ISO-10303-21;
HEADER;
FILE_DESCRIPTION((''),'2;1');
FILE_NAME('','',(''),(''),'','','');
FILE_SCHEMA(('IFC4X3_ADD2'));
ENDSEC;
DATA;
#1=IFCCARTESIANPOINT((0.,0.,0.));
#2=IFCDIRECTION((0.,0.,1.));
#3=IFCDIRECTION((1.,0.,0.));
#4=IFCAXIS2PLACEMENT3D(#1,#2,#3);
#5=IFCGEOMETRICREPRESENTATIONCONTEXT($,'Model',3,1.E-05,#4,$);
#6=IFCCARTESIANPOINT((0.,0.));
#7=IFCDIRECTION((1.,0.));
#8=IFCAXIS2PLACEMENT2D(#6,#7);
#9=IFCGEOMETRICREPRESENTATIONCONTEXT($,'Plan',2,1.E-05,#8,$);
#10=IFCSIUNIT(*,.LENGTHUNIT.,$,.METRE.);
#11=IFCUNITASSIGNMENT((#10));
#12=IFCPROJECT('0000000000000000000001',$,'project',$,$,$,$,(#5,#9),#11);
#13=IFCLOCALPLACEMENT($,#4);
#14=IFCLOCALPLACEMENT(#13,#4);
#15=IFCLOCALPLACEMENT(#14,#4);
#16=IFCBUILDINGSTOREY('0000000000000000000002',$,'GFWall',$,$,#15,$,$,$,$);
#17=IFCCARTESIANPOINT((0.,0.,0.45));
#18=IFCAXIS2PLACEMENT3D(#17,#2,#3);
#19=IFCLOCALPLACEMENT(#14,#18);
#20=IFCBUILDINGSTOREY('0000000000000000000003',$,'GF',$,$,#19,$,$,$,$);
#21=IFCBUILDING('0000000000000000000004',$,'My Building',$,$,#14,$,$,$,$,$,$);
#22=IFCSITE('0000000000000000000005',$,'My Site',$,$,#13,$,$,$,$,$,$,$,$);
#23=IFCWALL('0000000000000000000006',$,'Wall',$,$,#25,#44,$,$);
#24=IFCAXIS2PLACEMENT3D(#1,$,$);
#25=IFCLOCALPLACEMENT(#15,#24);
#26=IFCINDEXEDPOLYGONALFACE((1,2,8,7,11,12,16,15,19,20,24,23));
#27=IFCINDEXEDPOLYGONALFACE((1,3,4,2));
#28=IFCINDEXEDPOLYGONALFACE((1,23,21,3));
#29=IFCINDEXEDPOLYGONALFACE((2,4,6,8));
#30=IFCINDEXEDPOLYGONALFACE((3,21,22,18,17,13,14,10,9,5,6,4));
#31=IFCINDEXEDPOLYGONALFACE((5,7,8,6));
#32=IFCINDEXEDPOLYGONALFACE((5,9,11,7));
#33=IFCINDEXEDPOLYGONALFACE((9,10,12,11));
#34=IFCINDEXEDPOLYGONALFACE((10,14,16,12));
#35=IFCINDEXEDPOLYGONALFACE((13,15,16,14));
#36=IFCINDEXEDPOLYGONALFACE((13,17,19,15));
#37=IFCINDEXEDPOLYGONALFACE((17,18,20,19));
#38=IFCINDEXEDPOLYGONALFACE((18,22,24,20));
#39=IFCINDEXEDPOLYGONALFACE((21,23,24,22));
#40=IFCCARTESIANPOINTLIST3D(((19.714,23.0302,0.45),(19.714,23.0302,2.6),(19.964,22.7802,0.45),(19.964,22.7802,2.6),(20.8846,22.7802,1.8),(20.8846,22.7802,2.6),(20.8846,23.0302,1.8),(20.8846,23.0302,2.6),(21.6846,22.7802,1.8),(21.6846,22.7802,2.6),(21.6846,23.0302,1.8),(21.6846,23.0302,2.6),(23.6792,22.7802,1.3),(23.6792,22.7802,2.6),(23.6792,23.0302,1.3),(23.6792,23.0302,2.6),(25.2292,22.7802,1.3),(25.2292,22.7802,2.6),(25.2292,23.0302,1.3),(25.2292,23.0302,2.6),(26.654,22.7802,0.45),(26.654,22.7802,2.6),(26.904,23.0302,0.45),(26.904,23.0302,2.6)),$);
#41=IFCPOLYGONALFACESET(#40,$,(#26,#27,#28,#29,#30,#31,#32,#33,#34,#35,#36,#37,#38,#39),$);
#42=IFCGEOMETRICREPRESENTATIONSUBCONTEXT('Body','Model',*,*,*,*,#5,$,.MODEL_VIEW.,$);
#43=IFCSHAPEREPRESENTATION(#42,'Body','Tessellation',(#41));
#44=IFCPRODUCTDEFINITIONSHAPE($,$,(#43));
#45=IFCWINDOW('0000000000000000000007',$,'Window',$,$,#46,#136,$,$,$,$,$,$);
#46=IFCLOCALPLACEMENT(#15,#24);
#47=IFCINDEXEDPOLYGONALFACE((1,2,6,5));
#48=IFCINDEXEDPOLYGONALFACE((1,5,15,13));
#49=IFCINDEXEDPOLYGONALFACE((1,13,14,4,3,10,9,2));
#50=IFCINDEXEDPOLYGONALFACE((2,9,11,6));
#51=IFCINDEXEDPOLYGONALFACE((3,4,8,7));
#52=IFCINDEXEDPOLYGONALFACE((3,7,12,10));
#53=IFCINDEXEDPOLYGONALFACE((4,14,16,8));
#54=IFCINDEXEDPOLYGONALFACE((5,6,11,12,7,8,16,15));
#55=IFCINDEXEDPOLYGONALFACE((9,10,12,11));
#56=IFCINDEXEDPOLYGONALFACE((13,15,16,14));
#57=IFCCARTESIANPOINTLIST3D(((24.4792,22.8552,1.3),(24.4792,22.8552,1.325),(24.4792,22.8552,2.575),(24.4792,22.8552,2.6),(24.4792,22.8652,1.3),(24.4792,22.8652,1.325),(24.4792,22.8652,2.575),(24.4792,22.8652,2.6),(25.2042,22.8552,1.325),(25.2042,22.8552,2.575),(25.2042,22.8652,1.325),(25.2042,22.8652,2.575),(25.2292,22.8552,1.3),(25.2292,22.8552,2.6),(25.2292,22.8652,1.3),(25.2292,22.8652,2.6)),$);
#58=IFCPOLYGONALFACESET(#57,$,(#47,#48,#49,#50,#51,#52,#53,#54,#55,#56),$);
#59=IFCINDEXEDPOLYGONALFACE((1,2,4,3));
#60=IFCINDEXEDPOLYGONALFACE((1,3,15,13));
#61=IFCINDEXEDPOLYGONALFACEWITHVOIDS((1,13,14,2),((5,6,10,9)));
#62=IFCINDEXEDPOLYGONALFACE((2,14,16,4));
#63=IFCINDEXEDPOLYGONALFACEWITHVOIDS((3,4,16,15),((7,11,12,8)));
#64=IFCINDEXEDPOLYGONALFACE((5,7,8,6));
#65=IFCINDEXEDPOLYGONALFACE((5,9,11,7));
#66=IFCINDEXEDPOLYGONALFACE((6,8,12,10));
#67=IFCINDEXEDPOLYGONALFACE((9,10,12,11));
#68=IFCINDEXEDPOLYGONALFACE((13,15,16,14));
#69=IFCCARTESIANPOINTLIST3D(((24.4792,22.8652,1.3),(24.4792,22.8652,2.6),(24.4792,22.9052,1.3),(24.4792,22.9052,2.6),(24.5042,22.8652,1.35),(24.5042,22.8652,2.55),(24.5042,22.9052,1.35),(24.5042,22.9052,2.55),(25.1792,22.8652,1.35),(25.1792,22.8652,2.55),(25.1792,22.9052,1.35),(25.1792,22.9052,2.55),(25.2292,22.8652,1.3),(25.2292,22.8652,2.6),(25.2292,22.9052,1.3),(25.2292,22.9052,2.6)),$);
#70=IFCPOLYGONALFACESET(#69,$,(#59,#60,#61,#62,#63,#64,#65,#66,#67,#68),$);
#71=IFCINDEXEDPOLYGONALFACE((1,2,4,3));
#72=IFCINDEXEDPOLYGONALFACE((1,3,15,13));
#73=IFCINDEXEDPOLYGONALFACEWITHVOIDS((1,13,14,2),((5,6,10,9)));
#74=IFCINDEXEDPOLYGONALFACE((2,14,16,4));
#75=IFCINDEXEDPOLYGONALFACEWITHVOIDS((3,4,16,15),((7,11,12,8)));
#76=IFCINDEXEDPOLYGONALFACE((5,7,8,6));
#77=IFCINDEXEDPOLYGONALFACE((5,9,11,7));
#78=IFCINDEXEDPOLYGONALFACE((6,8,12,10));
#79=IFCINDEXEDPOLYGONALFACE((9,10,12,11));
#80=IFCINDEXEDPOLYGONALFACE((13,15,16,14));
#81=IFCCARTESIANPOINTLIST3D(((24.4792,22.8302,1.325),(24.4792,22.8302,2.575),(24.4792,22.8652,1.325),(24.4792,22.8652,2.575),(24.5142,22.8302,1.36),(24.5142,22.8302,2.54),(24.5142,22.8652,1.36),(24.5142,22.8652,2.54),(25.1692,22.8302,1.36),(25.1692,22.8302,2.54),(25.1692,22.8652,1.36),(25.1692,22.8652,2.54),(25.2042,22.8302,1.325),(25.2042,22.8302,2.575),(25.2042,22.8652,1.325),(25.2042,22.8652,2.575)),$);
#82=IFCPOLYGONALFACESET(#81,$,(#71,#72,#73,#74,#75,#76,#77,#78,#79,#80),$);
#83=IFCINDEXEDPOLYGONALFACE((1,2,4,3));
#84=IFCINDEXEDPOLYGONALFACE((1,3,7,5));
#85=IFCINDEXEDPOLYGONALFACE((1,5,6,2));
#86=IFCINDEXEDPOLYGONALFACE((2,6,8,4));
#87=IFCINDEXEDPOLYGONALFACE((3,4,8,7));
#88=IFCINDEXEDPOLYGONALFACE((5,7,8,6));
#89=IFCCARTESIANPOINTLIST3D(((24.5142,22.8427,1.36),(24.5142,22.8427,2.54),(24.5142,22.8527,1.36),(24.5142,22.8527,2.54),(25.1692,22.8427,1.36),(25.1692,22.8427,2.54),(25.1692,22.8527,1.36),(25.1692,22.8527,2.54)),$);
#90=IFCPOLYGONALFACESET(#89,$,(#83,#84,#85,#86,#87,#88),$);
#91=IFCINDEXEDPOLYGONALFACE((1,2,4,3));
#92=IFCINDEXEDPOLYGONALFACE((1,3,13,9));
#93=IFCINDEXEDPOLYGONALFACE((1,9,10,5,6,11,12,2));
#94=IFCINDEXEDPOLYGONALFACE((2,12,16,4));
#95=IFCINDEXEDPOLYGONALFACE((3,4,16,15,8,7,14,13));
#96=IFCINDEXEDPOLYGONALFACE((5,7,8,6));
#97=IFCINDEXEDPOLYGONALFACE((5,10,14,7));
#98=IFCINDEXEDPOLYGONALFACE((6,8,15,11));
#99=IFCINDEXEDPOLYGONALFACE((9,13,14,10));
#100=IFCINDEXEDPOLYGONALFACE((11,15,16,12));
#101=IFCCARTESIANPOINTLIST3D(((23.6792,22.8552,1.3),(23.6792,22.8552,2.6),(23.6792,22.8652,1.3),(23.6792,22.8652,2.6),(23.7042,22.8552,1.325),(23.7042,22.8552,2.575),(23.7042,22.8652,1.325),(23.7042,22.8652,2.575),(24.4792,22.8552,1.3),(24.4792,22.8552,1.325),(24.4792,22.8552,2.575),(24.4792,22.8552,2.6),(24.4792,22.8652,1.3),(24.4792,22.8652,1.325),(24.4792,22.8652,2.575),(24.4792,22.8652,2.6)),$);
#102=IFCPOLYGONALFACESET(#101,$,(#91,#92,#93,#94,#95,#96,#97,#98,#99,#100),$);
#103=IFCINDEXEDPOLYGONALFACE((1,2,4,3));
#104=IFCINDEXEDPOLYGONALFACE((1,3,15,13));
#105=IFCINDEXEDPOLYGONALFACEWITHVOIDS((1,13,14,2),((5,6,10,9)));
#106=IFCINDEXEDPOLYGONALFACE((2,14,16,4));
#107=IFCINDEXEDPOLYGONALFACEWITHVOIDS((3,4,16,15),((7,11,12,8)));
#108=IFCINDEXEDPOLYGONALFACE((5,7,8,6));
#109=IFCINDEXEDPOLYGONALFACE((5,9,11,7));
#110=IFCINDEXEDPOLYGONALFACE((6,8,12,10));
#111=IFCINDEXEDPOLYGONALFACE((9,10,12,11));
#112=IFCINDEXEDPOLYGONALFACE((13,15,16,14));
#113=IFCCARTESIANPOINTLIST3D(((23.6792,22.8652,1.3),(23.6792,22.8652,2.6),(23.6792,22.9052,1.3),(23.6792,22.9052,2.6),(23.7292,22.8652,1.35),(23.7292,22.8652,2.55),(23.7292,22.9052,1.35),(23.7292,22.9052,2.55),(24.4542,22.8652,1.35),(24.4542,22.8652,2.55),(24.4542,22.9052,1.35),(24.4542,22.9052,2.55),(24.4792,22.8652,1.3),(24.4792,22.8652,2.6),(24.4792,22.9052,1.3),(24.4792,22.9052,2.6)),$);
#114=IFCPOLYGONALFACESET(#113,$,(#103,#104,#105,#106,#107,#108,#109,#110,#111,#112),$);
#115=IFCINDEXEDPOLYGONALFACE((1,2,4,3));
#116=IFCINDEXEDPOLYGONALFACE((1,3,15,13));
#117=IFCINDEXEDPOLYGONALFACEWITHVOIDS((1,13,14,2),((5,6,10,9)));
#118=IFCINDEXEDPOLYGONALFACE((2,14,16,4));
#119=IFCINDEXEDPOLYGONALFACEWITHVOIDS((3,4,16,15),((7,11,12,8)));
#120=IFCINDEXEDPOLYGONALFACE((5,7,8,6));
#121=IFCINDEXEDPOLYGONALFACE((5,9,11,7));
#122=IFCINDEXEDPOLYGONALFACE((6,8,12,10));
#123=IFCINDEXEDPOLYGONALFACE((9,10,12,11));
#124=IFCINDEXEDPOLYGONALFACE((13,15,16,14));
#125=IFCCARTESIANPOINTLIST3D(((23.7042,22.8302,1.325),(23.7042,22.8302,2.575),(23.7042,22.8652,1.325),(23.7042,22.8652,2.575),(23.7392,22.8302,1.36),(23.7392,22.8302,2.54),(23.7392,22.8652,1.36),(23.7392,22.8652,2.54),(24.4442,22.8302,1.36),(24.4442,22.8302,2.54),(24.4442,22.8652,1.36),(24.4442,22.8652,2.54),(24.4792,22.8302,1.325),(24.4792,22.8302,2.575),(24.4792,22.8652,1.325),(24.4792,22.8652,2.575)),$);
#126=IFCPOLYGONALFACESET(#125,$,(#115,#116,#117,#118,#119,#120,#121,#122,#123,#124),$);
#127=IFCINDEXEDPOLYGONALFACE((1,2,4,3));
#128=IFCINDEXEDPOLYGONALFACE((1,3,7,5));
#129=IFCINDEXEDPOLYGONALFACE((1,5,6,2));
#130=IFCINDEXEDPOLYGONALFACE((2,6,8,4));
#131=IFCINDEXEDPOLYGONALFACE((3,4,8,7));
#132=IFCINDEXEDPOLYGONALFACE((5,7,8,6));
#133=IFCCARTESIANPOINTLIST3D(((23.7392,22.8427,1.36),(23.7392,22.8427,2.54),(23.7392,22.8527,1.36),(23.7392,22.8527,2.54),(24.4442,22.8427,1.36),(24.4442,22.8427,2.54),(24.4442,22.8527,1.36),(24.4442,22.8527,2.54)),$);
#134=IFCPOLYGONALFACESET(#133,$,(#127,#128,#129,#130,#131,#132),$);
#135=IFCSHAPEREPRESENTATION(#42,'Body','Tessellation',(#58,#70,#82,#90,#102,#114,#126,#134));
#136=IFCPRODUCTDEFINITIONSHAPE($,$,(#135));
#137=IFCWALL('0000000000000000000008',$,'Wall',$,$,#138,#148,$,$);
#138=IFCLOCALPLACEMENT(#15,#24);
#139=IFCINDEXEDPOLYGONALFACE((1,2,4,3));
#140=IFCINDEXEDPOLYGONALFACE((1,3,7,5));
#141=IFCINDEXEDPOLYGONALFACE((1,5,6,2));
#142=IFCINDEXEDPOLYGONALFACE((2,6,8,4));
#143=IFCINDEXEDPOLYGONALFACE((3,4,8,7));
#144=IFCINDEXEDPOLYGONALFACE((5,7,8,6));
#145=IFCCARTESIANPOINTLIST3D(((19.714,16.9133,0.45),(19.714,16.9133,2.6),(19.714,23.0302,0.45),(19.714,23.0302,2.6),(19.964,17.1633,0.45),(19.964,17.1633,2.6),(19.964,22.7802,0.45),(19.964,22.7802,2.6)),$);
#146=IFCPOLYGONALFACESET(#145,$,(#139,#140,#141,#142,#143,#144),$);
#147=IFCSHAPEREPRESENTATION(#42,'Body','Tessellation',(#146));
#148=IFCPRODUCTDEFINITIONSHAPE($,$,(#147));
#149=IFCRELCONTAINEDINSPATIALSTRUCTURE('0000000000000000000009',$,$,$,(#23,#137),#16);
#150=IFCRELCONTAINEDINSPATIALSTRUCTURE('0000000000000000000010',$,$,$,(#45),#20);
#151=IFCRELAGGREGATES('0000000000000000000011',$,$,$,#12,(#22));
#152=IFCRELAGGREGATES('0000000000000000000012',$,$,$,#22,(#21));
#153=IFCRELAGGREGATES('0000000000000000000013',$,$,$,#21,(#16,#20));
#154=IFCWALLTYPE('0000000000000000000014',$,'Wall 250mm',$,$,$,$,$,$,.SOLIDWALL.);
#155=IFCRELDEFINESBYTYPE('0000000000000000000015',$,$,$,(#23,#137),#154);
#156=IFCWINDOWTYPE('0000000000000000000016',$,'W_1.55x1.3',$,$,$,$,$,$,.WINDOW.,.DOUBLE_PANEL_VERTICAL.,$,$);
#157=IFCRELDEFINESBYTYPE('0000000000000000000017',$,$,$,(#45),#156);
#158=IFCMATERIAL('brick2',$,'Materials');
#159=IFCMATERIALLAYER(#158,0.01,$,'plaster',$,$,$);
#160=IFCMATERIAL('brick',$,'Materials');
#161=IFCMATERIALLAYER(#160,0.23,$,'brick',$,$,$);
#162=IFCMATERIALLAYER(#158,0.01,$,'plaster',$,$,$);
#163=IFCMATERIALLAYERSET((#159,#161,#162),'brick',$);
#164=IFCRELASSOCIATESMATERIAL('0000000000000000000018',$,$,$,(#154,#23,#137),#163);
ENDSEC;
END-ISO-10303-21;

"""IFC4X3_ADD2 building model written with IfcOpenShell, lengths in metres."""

from ifc_helpers import new_model, entity, si_unit, frame, origin_with_axes, origin_2d_with_axis, place, context, subcontext, project, spatial, line, indexed_curve, outline, extrude, shape, source, transform, mapped, material, layer, layer_set, layer_usage, type_object, type_shapes, element, fill, save


model = new_model("IFC4X3_ADD2")

# Units and contexts
model_context = context("Model", 3, precision=1e-05, world=origin_with_axes())
plan_context = context("Plan", 2, precision=1e-05, world=origin_2d_with_axis())
body_context_1 = subcontext(model_context, "Body", "Model", "MODEL_VIEW")
body_context_2 = subcontext(plan_context, "Body", "Plan", "PLAN_VIEW")
ifc_project = project(units=[si_unit("LENGTHUNIT", "METRE")], contexts=[model_context, plan_context])

# Site, building, storey
site_placement = place(None, origin_with_axes())
site = spatial("IfcSite", under=ifc_project, at=site_placement, Name="My Site")
building_placement = place(site_placement, origin_with_axes())
building = spatial("IfcBuilding", under=site, at=building_placement, Name="My Building")
storey_1_placement = place(building_placement, origin_with_axes())
storey_1 = spatial("IfcBuildingStorey", under=building, at=storey_1_placement, Name="GFWall")

# Shared definitions
ifc_material_1 = material(Name="brick2", Category="Materials")
ifc_layer_1 = layer(ifc_material_1, 0.01, Name="plaster")
ifc_material_2 = material(Name="brick", Category="Materials")
ifc_layer_2 = layer(ifc_material_2, 0.23, Name="brick")
ifc_layer_3 = layer(ifc_material_1, 0.01, Name="plaster")
ifc_layer_set_1 = layer_set([ifc_layer_1, ifc_layer_2, ifc_layer_3], Name="brick")
wall_type_1 = type_object("IfcWallType", Name="Wall 250mm", PredefinedType="SOLIDWALL", material=ifc_layer_set_1)
shared_shape_1 = source(origin_with_axes(), body_context_1, "Body", "SweptSolid", [
    extrude(outline(indexed_curve([(0.0, 0.0), (1.55, 0.0), (1.55, 1.3), (0.0, 1.3)], segments=[line(1, 2, 3, 4, 1)])), frame((0.0, -0.6, 0.0), z_axis=(0.0, -1.0, 0.0), x_axis=(1.0, 0.0, 0.0)), (0.0, 0.0, -1.0), 1.2),
])

# Shared definitions
storey_2_placement = place(building_placement, frame((0.0, 0.0, 0.45), z_axis=(0.0, 0.0, 1.0), x_axis=(1.0, 0.0, 0.0)))
storey_2 = spatial("IfcBuildingStorey", under=building, at=storey_2_placement, Name="GF")

# Shared definitions
window_type = type_object("IfcWindowType", Name="W_1.55x1.3", PartitioningType="DOUBLE_PANEL_VERTICAL", PredefinedType="WINDOW")
shared_shape_2 = source(origin_with_axes(), body_context_1, "Body", "SweptSolid", [
    extrude(outline(indexed_curve([(0.75, 0.0), (0.0, 0.0), (0.0, 1.3), (0.75, 1.3), (0.75, 1.275), (0.025, 1.275), (0.025, 0.025), (0.75, 0.025)], segments=[line(1, 2, 3, 4, 5, 6, 7, 8, 1)])), frame((0.0, 0.09, 0.0), z_axis=(0.0, -1.0, 0.0), x_axis=(1.0, 0.0, 0.0)), (0.0, 0.0, -1.0), 0.01),
    extrude(outline(indexed_curve([(0.0, 0.0), (0.75, 0.0), (0.75, 1.3), (0.0, 1.3)], segments=[line(1, 2, 3, 4, 1)]), holes=[indexed_curve([(0.05, 0.05), (0.725, 0.05), (0.725, 1.25), (0.05, 1.25)], segments=[line(1, 2, 3, 4, 1)])]), frame((0.0, 0.05, 0.0), z_axis=(0.0, -1.0, 0.0), x_axis=(1.0, 0.0, 0.0)), (0.0, 0.0, -1.0), 0.04),
    extrude(outline(indexed_curve([(0.0, 0.0), (0.725, 0.0), (0.725, 1.25), (0.0, 1.25)], segments=[line(1, 2, 3, 4, 1)]), holes=[indexed_curve([(0.035, 0.035), (0.69, 0.035), (0.69, 1.215), (0.035, 1.215)], segments=[line(1, 2, 3, 4, 1)])]), frame((0.025, 0.09, 0.025), z_axis=(0.0, -1.0, 0.0), x_axis=(1.0, 0.0, 0.0)), (0.0, 0.0, -1.0), 0.035),
    extrude(outline(indexed_curve([(0.035, 0.035), (0.69, 0.035), (0.69, 1.215), (0.035, 1.215)], segments=[line(1, 2, 3, 4, 1)])), frame((0.025, 0.1025, 0.025), z_axis=(0.0, -1.0, 0.0), x_axis=(1.0, 0.0, 0.0)), (0.0, 0.0, -1.0), 0.01),
    extrude(outline(indexed_curve([(0.0, 1.3), (0.8, 1.3), (0.8, 0.0), (0.0, 0.0), (0.0, 0.025), (0.775, 0.025), (0.775, 1.275), (0.0, 1.275)], segments=[line(1, 2, 3, 4, 5, 6, 7, 8, 1)])), frame((0.75, 0.09, 0.0), z_axis=(0.0, -1.0, 0.0), x_axis=(1.0, 0.0, 0.0)), (0.0, 0.0, -1.0), 0.01),
    extrude(outline(indexed_curve([(0.0, 0.0), (0.8, 0.0), (0.8, 1.3), (0.0, 1.3)], segments=[line(1, 2, 3, 4, 1)]), holes=[indexed_curve([(0.025, 0.05), (0.75, 0.05), (0.75, 1.25), (0.025, 1.25)], segments=[line(1, 2, 3, 4, 1)])]), frame((0.75, 0.05, 0.0), z_axis=(0.0, -1.0, 0.0), x_axis=(1.0, 0.0, 0.0)), (0.0, 0.0, -1.0), 0.04),
    extrude(outline(indexed_curve([(0.0, 0.0), (0.775, 0.0), (0.775, 1.25), (0.0, 1.25)], segments=[line(1, 2, 3, 4, 1)]), holes=[indexed_curve([(0.035, 0.035), (0.74, 0.035), (0.74, 1.215), (0.035, 1.215)], segments=[line(1, 2, 3, 4, 1)])]), frame((0.75, 0.09, 0.025), z_axis=(0.0, -1.0, 0.0), x_axis=(1.0, 0.0, 0.0)), (0.0, 0.0, -1.0), 0.035),
    extrude(outline(indexed_curve([(0.035, 0.035), (0.74, 0.035), (0.74, 1.215), (0.035, 1.215)], segments=[line(1, 2, 3, 4, 1)])), frame((0.75, 0.1025, 0.025), z_axis=(0.0, -1.0, 0.0), x_axis=(1.0, 0.0, 0.0)), (0.0, 0.0, -1.0), 0.01),
])
shared_shape_3 = source(origin_with_axes(), body_context_2, "Body", "Curve2D", [
    entity("IfcIndexedPolyCurve", entity("IfcCartesianPointList2D", [[0.05, 0.05], [0.725, 0.05]])),
    entity("IfcIndexedPolyCurve", entity("IfcCartesianPointList2D", [[0.0, 0.1], [0.025, 0.1], [0.025, 0.09], [0.05, 0.09], [0.05, 0.05], [0.0, 0.05]]), [entity("IfcLineIndex", [1, 2, 3, 4, 5, 6, 1])]),
    entity("IfcIndexedPolyCurve", entity("IfcCartesianPointList2D", [[0.75, 0.1], [0.75, 0.1], [0.75, 0.09], [0.725, 0.09], [0.725, 0.05], [0.75, 0.05]])),
    entity("IfcIndexedPolyCurve", entity("IfcCartesianPointList2D", [[0.025, 0.09], [0.06, 0.09], [0.06, 0.125], [0.025, 0.125]]), [entity("IfcLineIndex", [1, 2, 3, 4, 1])]),
    entity("IfcIndexedPolyCurve", entity("IfcCartesianPointList2D", [[0.75, 0.09], [0.715, 0.09], [0.715, 0.125], [0.75, 0.125]]), [entity("IfcLineIndex", [1, 2, 3, 4, 1])]),
    entity("IfcIndexedPolyCurve", entity("IfcCartesianPointList2D", [[0.06, 0.09], [0.715, 0.09]])),
    entity("IfcIndexedPolyCurve", entity("IfcCartesianPointList2D", [[0.06, 0.125], [0.715, 0.125]])),
    entity("IfcIndexedPolyCurve", entity("IfcCartesianPointList2D", [[0.06, 0.1075], [0.715, 0.1075]])),
    entity("IfcIndexedPolyCurve", entity("IfcCartesianPointList2D", [[0.775, 0.05], [1.5, 0.05]])),
    entity("IfcIndexedPolyCurve", entity("IfcCartesianPointList2D", [[0.75, 0.1], [0.75, 0.1], [0.75, 0.09], [0.775, 0.09], [0.775, 0.05], [0.75, 0.05]])),
    entity("IfcIndexedPolyCurve", entity("IfcCartesianPointList2D", [[1.55, 0.1], [1.525, 0.1], [1.525, 0.09], [1.5, 0.09], [1.5, 0.05], [1.55, 0.05]]), [entity("IfcLineIndex", [1, 2, 3, 4, 5, 6, 1])]),
    entity("IfcIndexedPolyCurve", entity("IfcCartesianPointList2D", [[0.75, 0.09], [0.785, 0.09], [0.785, 0.125], [0.75, 0.125]]), [entity("IfcLineIndex", [1, 2, 3, 4, 1])]),
    entity("IfcIndexedPolyCurve", entity("IfcCartesianPointList2D", [[1.525, 0.09], [1.49, 0.09], [1.49, 0.125], [1.525, 0.125]]), [entity("IfcLineIndex", [1, 2, 3, 4, 1])]),
    entity("IfcIndexedPolyCurve", entity("IfcCartesianPointList2D", [[0.785, 0.09], [1.49, 0.09]])),
    entity("IfcIndexedPolyCurve", entity("IfcCartesianPointList2D", [[0.785, 0.125], [1.49, 0.125]])),
    entity("IfcIndexedPolyCurve", entity("IfcCartesianPointList2D", [[0.785, 0.1075], [1.49, 0.1075]])),
])
type_shapes(window_type, [shared_shape_2, shared_shape_3])

# Wall, openings, window
ifc_layer_usage_1 = layer_usage(ifc_layer_set_1, "AXIS2", "POSITIVE", 0.0)
wall_1_placement = place(storey_1_placement, frame((26.904, 23.0302, 0.45), z_axis=(0.0, 0.0, 1.0), x_axis=(-1.0, 0.0, 0.0)))
wall_1 = element("IfcWall", 1, at=wall_1_placement, inside=storey_1, type_object=wall_type_1, material=ifc_layer_usage_1, Name="Wall", context=body_context_1, shape_type="SweptSolid", body=[
    extrude(outline(indexed_curve([(0.0, 0.0), (0.25, 0.25), (6.94, 0.25), (7.19, 0.0)], segments=[line(1, 2, 3, 4, 1)])), origin_with_axes(), (0.0, 0.0, 1.0), 2.15),
])
opening_1_placement = place(wall_1_placement, frame((1.6748, 0.075, 0.85), z_axis=(0.0, 0.0, 1.0), x_axis=(1.0, 0.0, 0.0)))
opening_1 = element("IfcOpeningElement", 2, at=opening_1_placement, cuts=wall_1, PredefinedType="OPENING", context=body_context_1, shape_type="MappedRepresentation", body=[
    mapped(shared_shape_1, transform((0.0, 0.0, 0.0), x_axis=(1.0, 0.0, 0.0), y_axis=(0.0, 1.0, 0.0), z_axis=(0.0, 0.0, 1.0), scale=1.0)),
])
shared_shape_4 = source(origin_with_axes(), body_context_1, "Body", "SweptSolid", [
    extrude(outline(indexed_curve([(0.0, 0.0), (0.8, 0.0), (0.8, 0.8), (0.0, 0.8)], segments=[line(1, 2, 3, 4, 1)])), frame((-0.4, -0.6, 0.0), z_axis=(0.0, -1.0, 0.0), x_axis=(1.0, 0.0, 0.0)), (0.0, 0.0, -1.0), 1.2),
])
opening_2_placement = place(wall_1_placement, frame((5.6194, 0.0, 1.35), z_axis=(0.0, 0.0, 1.0), x_axis=(1.0, 0.0, 0.0)))
element("IfcOpeningElement", 3, at=opening_2_placement, cuts=wall_1, PredefinedType="OPENING", context=body_context_1, shape_type="MappedRepresentation", body=[
    mapped(shared_shape_4, transform((0.0, 0.0, 0.0), x_axis=(1.0, 0.0, 0.0), y_axis=(0.0, 1.0, 0.0), z_axis=(0.0, 0.0, 1.0), scale=1.0)),
])
window_1_placement = place(opening_1_placement, frame((0.0, 0.0, 0.0), z_axis=(0.0, 0.0, 1.0), x_axis=(1.0, 0.0, 0.0)))
window_1 = element("IfcWindow", 4, at=window_1_placement, inside=storey_2, type_object=window_type, Name="Window", shapes=[
    shape(body_context_1, "Body", "MappedRepresentation", [mapped(shared_shape_2, transform((0.0, 0.0, 0.0), x_axis=(1.0, 0.0, 0.0), y_axis=(0.0, 1.0, 0.0), z_axis=(0.0, 0.0, 1.0), scale=1.0))]),
    shape(body_context_2, "Body", "MappedRepresentation", [mapped(shared_shape_3, transform((0.0, 0.0, 0.0), x_axis=(1.0, 0.0, 0.0), y_axis=(0.0, 1.0, 0.0), z_axis=(0.0, 0.0, 1.0), scale=1.0))]),
])
fill(opening_1, window_1)

# Wall
ifc_layer_usage_2 = layer_usage(ifc_layer_set_1, "AXIS2", "NEGATIVE", 0.0)
wall_2_placement = place(storey_1_placement, frame((19.714, 17.1633, 0.45), z_axis=(0.0, 0.0, 1.0), x_axis=(0.000001, 1.0, 0.0)))
element("IfcWall", 5, at=wall_2_placement, inside=storey_1, type_object=wall_type_1, material=ifc_layer_usage_2, Name="Wall", context=body_context_1, shape_type="SweptSolid", body=[
    extrude(outline(indexed_curve([(0.0, -0.25), (-0.25, 0.0), (5.8669, 0.0), (5.6169, -0.25)], segments=[line(1, 2, 3, 4, 1)])), origin_with_axes(), (0.0, 0.0, 1.0), 2.15),
])

save(model, "model.ifc")
